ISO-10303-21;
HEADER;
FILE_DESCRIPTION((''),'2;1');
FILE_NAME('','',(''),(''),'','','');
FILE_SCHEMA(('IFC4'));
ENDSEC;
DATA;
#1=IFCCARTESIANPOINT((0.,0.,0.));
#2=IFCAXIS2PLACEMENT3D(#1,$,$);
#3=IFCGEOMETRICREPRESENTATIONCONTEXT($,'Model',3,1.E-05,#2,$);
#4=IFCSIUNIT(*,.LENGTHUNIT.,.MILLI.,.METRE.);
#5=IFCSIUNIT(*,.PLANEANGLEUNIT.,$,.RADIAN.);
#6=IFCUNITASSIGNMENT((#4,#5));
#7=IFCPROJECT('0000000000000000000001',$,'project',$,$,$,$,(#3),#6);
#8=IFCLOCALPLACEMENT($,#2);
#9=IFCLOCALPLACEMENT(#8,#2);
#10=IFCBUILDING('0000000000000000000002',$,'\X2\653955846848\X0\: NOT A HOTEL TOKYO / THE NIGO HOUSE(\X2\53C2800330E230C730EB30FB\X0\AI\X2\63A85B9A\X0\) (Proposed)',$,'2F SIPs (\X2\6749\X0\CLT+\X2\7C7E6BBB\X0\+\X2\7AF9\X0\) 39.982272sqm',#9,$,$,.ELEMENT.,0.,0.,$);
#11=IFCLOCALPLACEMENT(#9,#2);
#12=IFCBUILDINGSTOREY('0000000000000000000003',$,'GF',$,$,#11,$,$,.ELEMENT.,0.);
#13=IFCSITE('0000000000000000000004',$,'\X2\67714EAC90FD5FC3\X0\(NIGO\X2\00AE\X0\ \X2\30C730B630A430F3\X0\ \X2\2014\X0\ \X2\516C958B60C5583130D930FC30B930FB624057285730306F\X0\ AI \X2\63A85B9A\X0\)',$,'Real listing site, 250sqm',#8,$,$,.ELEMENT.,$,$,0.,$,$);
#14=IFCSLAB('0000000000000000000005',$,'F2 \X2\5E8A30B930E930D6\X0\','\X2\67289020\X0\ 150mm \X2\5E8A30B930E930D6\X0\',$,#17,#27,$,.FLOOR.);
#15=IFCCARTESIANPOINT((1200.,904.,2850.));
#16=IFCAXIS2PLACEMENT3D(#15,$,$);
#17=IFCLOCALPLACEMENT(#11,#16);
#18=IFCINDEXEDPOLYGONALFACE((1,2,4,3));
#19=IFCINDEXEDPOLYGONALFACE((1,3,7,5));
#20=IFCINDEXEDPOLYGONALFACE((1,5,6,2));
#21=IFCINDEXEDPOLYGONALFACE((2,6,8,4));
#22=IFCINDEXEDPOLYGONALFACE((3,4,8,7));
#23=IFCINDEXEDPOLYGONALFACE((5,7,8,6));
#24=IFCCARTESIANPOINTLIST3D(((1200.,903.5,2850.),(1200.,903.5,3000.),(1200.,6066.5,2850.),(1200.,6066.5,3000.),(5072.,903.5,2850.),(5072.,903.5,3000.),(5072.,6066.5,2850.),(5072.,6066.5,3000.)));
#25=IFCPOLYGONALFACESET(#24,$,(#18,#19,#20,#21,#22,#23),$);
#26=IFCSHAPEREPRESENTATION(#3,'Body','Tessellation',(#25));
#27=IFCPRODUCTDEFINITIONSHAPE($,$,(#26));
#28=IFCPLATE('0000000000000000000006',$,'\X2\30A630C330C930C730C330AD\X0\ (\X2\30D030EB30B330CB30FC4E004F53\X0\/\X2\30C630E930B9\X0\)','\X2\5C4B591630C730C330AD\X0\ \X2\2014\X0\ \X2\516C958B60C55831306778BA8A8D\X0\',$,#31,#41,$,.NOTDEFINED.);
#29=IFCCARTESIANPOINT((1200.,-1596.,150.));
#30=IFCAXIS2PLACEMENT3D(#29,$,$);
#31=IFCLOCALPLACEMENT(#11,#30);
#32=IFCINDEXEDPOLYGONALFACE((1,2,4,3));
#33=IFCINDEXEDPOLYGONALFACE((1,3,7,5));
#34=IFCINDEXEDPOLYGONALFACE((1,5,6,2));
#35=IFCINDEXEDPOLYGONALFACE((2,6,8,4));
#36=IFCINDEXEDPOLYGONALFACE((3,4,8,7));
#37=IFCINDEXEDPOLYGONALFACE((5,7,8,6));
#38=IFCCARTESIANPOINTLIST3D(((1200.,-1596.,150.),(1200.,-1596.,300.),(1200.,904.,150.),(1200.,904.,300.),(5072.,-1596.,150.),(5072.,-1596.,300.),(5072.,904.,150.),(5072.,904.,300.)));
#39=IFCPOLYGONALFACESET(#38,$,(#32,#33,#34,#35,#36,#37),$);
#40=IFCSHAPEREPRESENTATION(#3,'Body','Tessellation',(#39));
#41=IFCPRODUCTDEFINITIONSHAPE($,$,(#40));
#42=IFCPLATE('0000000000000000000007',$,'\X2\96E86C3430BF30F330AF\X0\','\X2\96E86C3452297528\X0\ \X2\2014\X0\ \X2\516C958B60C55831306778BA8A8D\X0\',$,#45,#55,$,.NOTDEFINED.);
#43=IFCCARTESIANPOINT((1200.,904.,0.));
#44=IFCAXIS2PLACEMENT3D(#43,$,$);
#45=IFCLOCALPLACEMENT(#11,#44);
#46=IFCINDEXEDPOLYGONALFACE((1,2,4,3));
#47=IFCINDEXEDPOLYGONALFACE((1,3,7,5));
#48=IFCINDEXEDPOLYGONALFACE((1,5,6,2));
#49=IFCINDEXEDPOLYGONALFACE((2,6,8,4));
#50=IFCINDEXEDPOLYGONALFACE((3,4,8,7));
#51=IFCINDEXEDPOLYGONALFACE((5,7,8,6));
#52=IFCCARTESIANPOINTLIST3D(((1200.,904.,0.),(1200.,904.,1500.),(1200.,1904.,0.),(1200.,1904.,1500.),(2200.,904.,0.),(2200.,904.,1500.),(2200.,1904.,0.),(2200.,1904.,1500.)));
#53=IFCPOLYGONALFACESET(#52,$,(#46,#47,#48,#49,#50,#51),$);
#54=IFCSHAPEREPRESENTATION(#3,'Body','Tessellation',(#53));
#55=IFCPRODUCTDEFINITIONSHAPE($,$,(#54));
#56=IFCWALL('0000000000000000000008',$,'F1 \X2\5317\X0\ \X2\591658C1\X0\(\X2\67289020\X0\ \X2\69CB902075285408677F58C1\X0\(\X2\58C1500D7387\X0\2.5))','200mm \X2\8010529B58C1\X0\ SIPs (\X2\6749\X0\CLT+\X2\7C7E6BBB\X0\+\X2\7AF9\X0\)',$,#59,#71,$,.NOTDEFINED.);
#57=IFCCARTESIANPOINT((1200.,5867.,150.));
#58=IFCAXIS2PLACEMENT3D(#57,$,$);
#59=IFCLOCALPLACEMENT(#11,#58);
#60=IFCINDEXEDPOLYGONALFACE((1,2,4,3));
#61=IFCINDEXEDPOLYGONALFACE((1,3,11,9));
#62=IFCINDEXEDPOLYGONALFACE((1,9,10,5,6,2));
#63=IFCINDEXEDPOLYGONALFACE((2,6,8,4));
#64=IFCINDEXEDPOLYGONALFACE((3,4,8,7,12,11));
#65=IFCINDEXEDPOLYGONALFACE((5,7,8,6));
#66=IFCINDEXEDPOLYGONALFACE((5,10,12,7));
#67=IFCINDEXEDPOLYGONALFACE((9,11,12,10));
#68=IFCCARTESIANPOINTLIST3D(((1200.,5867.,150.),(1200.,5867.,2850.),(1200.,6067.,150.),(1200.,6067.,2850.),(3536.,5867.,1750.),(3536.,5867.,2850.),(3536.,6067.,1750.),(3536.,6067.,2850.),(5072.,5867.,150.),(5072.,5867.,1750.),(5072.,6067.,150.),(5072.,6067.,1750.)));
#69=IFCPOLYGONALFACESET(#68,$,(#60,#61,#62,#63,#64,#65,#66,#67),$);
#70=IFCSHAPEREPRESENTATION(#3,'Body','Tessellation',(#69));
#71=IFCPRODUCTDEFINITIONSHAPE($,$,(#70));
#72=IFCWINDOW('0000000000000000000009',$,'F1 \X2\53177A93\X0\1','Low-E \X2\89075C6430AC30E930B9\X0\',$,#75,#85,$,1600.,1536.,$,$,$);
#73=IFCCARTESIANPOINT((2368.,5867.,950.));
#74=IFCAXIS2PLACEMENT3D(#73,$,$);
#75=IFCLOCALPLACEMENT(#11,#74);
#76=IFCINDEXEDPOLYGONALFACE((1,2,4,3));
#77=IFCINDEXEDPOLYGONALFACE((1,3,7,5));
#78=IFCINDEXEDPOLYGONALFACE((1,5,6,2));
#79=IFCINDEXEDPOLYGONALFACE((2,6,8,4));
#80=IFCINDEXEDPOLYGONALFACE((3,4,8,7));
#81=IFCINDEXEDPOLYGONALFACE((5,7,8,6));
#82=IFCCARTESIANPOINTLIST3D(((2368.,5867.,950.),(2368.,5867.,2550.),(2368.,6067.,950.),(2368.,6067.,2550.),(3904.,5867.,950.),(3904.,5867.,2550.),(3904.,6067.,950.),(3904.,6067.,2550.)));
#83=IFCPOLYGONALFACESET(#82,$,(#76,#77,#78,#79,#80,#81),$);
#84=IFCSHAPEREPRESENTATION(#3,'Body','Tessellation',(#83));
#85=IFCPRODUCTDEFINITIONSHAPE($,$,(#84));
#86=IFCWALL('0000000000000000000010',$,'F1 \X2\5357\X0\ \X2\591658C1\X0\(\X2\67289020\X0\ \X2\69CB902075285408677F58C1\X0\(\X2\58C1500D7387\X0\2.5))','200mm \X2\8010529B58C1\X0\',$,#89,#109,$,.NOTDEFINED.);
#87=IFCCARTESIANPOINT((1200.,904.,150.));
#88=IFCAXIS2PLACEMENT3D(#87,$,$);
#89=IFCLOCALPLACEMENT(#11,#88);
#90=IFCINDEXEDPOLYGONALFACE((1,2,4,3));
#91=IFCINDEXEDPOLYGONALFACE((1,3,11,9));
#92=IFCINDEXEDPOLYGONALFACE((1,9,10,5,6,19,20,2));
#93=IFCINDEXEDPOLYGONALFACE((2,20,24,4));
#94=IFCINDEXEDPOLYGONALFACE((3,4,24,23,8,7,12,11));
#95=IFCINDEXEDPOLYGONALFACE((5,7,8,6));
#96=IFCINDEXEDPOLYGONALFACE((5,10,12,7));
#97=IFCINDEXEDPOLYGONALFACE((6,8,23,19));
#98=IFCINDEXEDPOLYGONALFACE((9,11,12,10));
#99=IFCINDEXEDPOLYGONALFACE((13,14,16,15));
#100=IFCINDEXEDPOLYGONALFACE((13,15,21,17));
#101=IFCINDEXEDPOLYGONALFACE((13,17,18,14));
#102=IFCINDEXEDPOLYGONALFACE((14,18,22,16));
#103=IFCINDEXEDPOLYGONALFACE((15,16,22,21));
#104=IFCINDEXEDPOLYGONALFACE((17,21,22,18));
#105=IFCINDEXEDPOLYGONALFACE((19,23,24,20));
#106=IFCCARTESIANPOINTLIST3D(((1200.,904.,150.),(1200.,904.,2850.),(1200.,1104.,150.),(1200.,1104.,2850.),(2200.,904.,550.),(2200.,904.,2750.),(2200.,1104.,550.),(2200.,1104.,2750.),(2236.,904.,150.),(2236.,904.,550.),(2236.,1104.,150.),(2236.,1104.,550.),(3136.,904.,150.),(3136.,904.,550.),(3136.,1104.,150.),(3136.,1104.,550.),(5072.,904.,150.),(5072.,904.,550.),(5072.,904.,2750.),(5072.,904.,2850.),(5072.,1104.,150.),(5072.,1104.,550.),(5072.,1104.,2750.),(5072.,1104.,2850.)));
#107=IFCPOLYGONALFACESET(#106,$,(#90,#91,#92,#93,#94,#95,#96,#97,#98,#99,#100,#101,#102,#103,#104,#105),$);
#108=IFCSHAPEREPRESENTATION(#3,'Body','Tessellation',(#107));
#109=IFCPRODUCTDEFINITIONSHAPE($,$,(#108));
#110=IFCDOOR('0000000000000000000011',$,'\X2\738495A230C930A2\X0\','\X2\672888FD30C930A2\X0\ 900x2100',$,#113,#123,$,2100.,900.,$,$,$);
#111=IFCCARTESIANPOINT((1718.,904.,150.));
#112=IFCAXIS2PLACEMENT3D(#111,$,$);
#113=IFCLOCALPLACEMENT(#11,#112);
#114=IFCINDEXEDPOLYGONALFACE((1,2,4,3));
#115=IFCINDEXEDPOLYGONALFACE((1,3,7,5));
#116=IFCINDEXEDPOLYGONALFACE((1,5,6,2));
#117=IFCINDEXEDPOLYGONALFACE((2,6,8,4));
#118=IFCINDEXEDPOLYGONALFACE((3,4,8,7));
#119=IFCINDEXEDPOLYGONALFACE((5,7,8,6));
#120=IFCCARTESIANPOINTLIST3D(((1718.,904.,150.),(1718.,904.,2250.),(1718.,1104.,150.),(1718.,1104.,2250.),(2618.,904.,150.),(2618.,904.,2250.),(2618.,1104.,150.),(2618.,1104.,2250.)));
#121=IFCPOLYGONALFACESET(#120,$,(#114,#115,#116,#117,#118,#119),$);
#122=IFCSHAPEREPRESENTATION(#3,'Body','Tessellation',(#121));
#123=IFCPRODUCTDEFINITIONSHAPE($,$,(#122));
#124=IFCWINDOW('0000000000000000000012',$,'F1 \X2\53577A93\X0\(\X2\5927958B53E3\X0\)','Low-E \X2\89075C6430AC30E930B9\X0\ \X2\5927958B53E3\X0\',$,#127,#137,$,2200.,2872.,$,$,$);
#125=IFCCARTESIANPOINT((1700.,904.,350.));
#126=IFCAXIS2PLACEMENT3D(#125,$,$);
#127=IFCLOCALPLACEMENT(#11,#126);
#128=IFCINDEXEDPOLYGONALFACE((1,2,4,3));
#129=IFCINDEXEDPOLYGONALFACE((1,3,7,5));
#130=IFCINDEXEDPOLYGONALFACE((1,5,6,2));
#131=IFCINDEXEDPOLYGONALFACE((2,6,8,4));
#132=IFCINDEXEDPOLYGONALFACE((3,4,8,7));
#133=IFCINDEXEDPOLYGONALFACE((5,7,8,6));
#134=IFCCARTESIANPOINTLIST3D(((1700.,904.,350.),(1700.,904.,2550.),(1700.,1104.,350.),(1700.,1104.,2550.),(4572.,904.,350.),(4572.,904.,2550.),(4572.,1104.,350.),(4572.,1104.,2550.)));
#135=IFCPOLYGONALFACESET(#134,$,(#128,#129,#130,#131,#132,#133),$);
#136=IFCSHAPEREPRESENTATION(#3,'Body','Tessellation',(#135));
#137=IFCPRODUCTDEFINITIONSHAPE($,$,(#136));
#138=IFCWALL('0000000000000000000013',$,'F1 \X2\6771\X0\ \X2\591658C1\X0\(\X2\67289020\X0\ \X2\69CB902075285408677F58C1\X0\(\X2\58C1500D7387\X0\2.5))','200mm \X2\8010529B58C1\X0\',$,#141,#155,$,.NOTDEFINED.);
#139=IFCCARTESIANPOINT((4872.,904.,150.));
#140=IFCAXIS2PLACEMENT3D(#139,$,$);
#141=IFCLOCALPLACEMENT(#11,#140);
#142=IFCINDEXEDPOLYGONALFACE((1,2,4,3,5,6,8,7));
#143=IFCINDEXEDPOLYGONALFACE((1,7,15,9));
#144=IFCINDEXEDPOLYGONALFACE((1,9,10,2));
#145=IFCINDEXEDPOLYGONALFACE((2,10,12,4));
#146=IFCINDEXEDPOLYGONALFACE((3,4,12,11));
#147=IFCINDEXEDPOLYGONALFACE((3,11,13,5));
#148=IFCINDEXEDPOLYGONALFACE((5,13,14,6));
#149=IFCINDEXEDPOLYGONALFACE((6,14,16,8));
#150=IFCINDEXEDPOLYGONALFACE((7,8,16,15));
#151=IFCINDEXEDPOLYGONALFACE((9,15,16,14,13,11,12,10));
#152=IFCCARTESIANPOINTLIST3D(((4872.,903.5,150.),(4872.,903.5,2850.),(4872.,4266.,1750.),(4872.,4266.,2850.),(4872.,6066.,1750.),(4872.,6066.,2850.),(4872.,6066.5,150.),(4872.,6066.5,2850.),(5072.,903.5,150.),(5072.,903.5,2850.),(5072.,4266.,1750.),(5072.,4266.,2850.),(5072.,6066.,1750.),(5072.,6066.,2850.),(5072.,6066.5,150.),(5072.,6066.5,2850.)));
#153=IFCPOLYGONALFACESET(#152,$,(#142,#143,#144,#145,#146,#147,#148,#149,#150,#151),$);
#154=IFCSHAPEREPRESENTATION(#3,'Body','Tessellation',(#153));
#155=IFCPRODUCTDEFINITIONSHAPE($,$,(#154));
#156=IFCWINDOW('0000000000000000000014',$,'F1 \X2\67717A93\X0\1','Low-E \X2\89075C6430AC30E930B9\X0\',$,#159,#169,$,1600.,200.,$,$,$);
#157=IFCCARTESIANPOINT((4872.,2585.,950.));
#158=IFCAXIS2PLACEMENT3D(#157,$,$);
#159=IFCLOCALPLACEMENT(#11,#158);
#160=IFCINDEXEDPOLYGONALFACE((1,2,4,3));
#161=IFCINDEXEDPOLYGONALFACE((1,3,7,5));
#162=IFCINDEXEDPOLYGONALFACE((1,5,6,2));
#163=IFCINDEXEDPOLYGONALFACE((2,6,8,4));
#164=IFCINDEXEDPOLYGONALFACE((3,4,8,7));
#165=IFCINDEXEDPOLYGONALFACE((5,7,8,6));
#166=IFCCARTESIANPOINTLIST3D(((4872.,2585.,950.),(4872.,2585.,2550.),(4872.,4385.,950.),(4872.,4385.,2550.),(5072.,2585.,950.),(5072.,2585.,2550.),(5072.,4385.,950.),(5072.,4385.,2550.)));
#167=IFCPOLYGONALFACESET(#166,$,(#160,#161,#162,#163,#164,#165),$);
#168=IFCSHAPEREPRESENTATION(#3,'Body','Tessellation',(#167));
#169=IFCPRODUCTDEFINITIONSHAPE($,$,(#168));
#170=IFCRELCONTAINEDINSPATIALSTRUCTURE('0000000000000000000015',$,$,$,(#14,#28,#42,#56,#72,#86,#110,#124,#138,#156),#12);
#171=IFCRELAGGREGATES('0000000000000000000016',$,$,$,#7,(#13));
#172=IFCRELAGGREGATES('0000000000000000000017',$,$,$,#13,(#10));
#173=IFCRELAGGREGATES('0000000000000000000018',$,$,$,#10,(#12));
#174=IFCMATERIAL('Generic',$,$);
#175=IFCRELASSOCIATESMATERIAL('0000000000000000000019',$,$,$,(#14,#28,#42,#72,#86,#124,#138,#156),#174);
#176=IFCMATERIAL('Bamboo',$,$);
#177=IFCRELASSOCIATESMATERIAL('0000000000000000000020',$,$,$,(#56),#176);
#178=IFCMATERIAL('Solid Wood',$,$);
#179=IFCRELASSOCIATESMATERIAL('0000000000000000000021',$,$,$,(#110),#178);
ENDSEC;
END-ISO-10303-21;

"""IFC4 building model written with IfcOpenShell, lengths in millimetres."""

from ifc_helpers import new_model, si_unit, frame, frame_2d, origin, place, context, project, spatial, rectangle, extrude, material, element, fill, save


model = new_model("IFC4")

# Units and contexts
model_context = context("Model", 3, precision=1e-05, world=origin())
ifc_project = project(units=[si_unit("LENGTHUNIT", "METRE", prefix="MILLI"), si_unit("PLANEANGLEUNIT", "RADIAN")], contexts=[model_context])

# Site, building, storey
site_placement = place(None, origin())
site = spatial("IfcSite", under=ifc_project, at=site_placement, Name="東京都心(NIGO® デザイン — 公開情報ベース・所在地は AI 推定)", ObjectType="Real listing site, 250sqm", CompositionType="ELEMENT", RefElevation=0.0)
building_placement = place(site_placement, origin())
building = spatial("IfcBuilding", under=site, at=building_placement, Name="改善案: NOT A HOTEL TOKYO / THE NIGO HOUSE(参考モデル・AI推定) (Proposed)", ObjectType="2F SIPs (杉CLT+籾殻+竹) 39.982272sqm", CompositionType="ELEMENT", ElevationOfRefHeight=0.0, ElevationOfTerrain=0.0)
storey_placement = place(building_placement, origin())
storey = spatial("IfcBuildingStorey", under=building, at=storey_placement, Name="GF", CompositionType="ELEMENT", Elevation=0.0)

# Slab
ifc_material_1 = material(Name="Generic")
slab_1_placement = place(storey_placement, frame((1200.0, 904.0, 2850.0)))
element("IfcSlab", 1, at=slab_1_placement, inside=storey, material=ifc_material_1, Name="F2 床スラブ", Description="木造 150mm 床スラブ", PredefinedType="FLOOR", context=model_context, shape_type="SweptSolid", body=[
    extrude(rectangle(XDim=3872.0, YDim=5163.0, at=frame_2d((1936.0, 2581.0))), frame((1200.0, 904.0, 2850.0)), (0.0, 0.0, 1.0), 150.0),
])

# Plates
plate_1_placement = place(storey_placement, frame((1200.0, -1596.0, 150.0)))
element("IfcPlate", 2, at=plate_1_placement, inside=storey, material=ifc_material_1, Name="ウッドデッキ (バルコニー一体/テラス)", Description="屋外デッキ — 公開情報で確認", PredefinedType="NOTDEFINED", context=model_context, shape_type="SweptSolid", body=[
    extrude(rectangle(XDim=3872.0, YDim=2500.0, at=frame_2d((1936.0, 1250.0))), frame((1200.0, -1596.0, 150.0)), (0.0, 0.0, 1.0), 150.0),
])
plate_2_placement = place(storey_placement, frame((1200.0, 904.0, 0.0)))
element("IfcPlate", 3, at=plate_2_placement, inside=storey, material=ifc_material_1, Name="雨水タンク", Description="雨水利用 — 公開情報で確認", PredefinedType="NOTDEFINED", context=model_context, shape_type="SweptSolid", body=[
    extrude(rectangle(XDim=1000.0, YDim=1000.0, at=frame_2d((500.0, 500.0))), frame((1200.0, 904.0, 0.0)), (0.0, 0.0, 1.0), 1500.0),
])

# Wall, opening, window
ifc_material_2 = material(Name="Bamboo")
wall_1_placement = place(storey_placement, frame((1200.0, 5867.0, 150.0)))
wall_1 = element("IfcWall", 4, at=wall_1_placement, inside=storey, material=ifc_material_2, Name="F1 北 外壁(木造 構造用合板壁(壁倍率2.5))", Description="200mm 耐力壁 SIPs (杉CLT+籾殻+竹)", PredefinedType="NOTDEFINED", context=model_context, shape_type="SweptSolid", body=[
    extrude(rectangle(XDim=3872.0, YDim=200.0, at=frame_2d((1936.0, 100.0))), frame((1200.0, 5867.0, 150.0)), (0.0, 0.0, 1.0), 2700.0),
])
opening_1_placement = place(storey_placement, frame((2368.0, 5867.0, 950.0)))
opening_1 = element("IfcOpeningElement", 5, at=opening_1_placement, cuts=wall_1, PredefinedType="NOTDEFINED", context=model_context, shape_type="SweptSolid", body=[
    extrude(rectangle(XDim=1536.0, YDim=200.0, at=frame_2d((768.0, 100.0))), frame((2368.0, 5867.0, 950.0)), (0.0, 0.0, 1.0), 1600.0),
])
window_1_placement = place(storey_placement, frame((2368.0, 5867.0, 950.0)))
window_1 = element("IfcWindow", 6, at=window_1_placement, inside=storey, material=ifc_material_1, Name="F1 北窓1", Description="Low-E 複層ガラス", OverallHeight=1600.0, OverallWidth=1536.0, context=model_context, shape_type="SweptSolid", body=[
    extrude(rectangle(XDim=1536.0, YDim=200.0, at=frame_2d((768.0, 100.0))), frame((2368.0, 5867.0, 950.0)), (0.0, 0.0, 1.0), 1600.0),
])
fill(opening_1, window_1)

# Wall, openings, door, window
wall_2_placement = place(storey_placement, frame((1200.0, 904.0, 150.0)))
wall_2 = element("IfcWall", 7, at=wall_2_placement, inside=storey, material=ifc_material_1, Name="F1 南 外壁(木造 構造用合板壁(壁倍率2.5))", Description="200mm 耐力壁", PredefinedType="NOTDEFINED", context=model_context, shape_type="SweptSolid", body=[
    extrude(rectangle(XDim=3872.0, YDim=200.0, at=frame_2d((1936.0, 100.0))), frame((1200.0, 904.0, 150.0)), (0.0, 0.0, 1.0), 2700.0),
])
opening_2_placement = place(storey_placement, frame((1718.0, 904.0, 150.0)))
opening_2 = element("IfcOpeningElement", 8, at=opening_2_placement, cuts=wall_2, PredefinedType="NOTDEFINED", context=model_context, shape_type="SweptSolid", body=[
    extrude(rectangle(XDim=900.0, YDim=200.0, at=frame_2d((450.0, 100.0))), frame((1718.0, 904.0, 150.0)), (0.0, 0.0, 1.0), 2100.0),
])
opening_3_placement = place(storey_placement, frame((1700.0, 904.0, 350.0)))
opening_3 = element("IfcOpeningElement", 9, at=opening_3_placement, cuts=wall_2, PredefinedType="NOTDEFINED", context=model_context, shape_type="SweptSolid", body=[
    extrude(rectangle(XDim=2872.0, YDim=200.0, at=frame_2d((1436.0, 100.0))), frame((1700.0, 904.0, 350.0)), (0.0, 0.0, 1.0), 2200.0),
])
ifc_material_3 = material(Name="Solid Wood")
door_placement = place(storey_placement, frame((1718.0, 904.0, 150.0)))
door = element("IfcDoor", 10, at=door_placement, inside=storey, material=ifc_material_3, Name="玄関ドア", Description="木製ドア 900x2100", OverallHeight=2100.0, OverallWidth=900.0, context=model_context, shape_type="SweptSolid", body=[
    extrude(rectangle(XDim=900.0, YDim=200.0, at=frame_2d((450.0, 100.0))), frame((1718.0, 904.0, 150.0)), (0.0, 0.0, 1.0), 2100.0),
])
fill(opening_2, door)
window_2_placement = place(storey_placement, frame((1700.0, 904.0, 350.0)))
window_2 = element("IfcWindow", 11, at=window_2_placement, inside=storey, material=ifc_material_1, Name="F1 南窓(大開口)", Description="Low-E 複層ガラス 大開口", OverallHeight=2200.0, OverallWidth=2872.0, context=model_context, shape_type="SweptSolid", body=[
    extrude(rectangle(XDim=2872.0, YDim=200.0, at=frame_2d((1436.0, 100.0))), frame((1700.0, 904.0, 350.0)), (0.0, 0.0, 1.0), 2200.0),
])
fill(opening_3, window_2)

# Wall, opening, window
wall_3_placement = place(storey_placement, frame((4872.0, 904.0, 150.0)))
wall_3 = element("IfcWall", 12, at=wall_3_placement, inside=storey, material=ifc_material_1, Name="F1 東 外壁(木造 構造用合板壁(壁倍率2.5))", Description="200mm 耐力壁", PredefinedType="NOTDEFINED", context=model_context, shape_type="SweptSolid", body=[
    extrude(rectangle(XDim=200.0, YDim=5163.0, at=frame_2d((100.0, 2581.0))), frame((4872.0, 904.0, 150.0)), (0.0, 0.0, 1.0), 2700.0),
])
opening_4_placement = place(storey_placement, frame((4872.0, 2585.0, 950.0)))
opening_4 = element("IfcOpeningElement", 13, at=opening_4_placement, cuts=wall_3, PredefinedType="NOTDEFINED", context=model_context, shape_type="SweptSolid", body=[
    extrude(rectangle(XDim=200.0, YDim=1800.0, at=frame_2d((100.0, 900.0))), frame((4872.0, 2585.0, 950.0)), (0.0, 0.0, 1.0), 1600.0),
])
window_3_placement = place(storey_placement, frame((4872.0, 2585.0, 950.0)))
window_3 = element("IfcWindow", 14, at=window_3_placement, inside=storey, material=ifc_material_1, Name="F1 東窓1", Description="Low-E 複層ガラス", OverallHeight=1600.0, OverallWidth=200.0, context=model_context, shape_type="SweptSolid", body=[
    extrude(rectangle(XDim=200.0, YDim=1800.0, at=frame_2d((100.0, 900.0))), frame((4872.0, 2585.0, 950.0)), (0.0, 0.0, 1.0), 1600.0),
])
fill(opening_4, window_3)

save(model, "model.ifc")
